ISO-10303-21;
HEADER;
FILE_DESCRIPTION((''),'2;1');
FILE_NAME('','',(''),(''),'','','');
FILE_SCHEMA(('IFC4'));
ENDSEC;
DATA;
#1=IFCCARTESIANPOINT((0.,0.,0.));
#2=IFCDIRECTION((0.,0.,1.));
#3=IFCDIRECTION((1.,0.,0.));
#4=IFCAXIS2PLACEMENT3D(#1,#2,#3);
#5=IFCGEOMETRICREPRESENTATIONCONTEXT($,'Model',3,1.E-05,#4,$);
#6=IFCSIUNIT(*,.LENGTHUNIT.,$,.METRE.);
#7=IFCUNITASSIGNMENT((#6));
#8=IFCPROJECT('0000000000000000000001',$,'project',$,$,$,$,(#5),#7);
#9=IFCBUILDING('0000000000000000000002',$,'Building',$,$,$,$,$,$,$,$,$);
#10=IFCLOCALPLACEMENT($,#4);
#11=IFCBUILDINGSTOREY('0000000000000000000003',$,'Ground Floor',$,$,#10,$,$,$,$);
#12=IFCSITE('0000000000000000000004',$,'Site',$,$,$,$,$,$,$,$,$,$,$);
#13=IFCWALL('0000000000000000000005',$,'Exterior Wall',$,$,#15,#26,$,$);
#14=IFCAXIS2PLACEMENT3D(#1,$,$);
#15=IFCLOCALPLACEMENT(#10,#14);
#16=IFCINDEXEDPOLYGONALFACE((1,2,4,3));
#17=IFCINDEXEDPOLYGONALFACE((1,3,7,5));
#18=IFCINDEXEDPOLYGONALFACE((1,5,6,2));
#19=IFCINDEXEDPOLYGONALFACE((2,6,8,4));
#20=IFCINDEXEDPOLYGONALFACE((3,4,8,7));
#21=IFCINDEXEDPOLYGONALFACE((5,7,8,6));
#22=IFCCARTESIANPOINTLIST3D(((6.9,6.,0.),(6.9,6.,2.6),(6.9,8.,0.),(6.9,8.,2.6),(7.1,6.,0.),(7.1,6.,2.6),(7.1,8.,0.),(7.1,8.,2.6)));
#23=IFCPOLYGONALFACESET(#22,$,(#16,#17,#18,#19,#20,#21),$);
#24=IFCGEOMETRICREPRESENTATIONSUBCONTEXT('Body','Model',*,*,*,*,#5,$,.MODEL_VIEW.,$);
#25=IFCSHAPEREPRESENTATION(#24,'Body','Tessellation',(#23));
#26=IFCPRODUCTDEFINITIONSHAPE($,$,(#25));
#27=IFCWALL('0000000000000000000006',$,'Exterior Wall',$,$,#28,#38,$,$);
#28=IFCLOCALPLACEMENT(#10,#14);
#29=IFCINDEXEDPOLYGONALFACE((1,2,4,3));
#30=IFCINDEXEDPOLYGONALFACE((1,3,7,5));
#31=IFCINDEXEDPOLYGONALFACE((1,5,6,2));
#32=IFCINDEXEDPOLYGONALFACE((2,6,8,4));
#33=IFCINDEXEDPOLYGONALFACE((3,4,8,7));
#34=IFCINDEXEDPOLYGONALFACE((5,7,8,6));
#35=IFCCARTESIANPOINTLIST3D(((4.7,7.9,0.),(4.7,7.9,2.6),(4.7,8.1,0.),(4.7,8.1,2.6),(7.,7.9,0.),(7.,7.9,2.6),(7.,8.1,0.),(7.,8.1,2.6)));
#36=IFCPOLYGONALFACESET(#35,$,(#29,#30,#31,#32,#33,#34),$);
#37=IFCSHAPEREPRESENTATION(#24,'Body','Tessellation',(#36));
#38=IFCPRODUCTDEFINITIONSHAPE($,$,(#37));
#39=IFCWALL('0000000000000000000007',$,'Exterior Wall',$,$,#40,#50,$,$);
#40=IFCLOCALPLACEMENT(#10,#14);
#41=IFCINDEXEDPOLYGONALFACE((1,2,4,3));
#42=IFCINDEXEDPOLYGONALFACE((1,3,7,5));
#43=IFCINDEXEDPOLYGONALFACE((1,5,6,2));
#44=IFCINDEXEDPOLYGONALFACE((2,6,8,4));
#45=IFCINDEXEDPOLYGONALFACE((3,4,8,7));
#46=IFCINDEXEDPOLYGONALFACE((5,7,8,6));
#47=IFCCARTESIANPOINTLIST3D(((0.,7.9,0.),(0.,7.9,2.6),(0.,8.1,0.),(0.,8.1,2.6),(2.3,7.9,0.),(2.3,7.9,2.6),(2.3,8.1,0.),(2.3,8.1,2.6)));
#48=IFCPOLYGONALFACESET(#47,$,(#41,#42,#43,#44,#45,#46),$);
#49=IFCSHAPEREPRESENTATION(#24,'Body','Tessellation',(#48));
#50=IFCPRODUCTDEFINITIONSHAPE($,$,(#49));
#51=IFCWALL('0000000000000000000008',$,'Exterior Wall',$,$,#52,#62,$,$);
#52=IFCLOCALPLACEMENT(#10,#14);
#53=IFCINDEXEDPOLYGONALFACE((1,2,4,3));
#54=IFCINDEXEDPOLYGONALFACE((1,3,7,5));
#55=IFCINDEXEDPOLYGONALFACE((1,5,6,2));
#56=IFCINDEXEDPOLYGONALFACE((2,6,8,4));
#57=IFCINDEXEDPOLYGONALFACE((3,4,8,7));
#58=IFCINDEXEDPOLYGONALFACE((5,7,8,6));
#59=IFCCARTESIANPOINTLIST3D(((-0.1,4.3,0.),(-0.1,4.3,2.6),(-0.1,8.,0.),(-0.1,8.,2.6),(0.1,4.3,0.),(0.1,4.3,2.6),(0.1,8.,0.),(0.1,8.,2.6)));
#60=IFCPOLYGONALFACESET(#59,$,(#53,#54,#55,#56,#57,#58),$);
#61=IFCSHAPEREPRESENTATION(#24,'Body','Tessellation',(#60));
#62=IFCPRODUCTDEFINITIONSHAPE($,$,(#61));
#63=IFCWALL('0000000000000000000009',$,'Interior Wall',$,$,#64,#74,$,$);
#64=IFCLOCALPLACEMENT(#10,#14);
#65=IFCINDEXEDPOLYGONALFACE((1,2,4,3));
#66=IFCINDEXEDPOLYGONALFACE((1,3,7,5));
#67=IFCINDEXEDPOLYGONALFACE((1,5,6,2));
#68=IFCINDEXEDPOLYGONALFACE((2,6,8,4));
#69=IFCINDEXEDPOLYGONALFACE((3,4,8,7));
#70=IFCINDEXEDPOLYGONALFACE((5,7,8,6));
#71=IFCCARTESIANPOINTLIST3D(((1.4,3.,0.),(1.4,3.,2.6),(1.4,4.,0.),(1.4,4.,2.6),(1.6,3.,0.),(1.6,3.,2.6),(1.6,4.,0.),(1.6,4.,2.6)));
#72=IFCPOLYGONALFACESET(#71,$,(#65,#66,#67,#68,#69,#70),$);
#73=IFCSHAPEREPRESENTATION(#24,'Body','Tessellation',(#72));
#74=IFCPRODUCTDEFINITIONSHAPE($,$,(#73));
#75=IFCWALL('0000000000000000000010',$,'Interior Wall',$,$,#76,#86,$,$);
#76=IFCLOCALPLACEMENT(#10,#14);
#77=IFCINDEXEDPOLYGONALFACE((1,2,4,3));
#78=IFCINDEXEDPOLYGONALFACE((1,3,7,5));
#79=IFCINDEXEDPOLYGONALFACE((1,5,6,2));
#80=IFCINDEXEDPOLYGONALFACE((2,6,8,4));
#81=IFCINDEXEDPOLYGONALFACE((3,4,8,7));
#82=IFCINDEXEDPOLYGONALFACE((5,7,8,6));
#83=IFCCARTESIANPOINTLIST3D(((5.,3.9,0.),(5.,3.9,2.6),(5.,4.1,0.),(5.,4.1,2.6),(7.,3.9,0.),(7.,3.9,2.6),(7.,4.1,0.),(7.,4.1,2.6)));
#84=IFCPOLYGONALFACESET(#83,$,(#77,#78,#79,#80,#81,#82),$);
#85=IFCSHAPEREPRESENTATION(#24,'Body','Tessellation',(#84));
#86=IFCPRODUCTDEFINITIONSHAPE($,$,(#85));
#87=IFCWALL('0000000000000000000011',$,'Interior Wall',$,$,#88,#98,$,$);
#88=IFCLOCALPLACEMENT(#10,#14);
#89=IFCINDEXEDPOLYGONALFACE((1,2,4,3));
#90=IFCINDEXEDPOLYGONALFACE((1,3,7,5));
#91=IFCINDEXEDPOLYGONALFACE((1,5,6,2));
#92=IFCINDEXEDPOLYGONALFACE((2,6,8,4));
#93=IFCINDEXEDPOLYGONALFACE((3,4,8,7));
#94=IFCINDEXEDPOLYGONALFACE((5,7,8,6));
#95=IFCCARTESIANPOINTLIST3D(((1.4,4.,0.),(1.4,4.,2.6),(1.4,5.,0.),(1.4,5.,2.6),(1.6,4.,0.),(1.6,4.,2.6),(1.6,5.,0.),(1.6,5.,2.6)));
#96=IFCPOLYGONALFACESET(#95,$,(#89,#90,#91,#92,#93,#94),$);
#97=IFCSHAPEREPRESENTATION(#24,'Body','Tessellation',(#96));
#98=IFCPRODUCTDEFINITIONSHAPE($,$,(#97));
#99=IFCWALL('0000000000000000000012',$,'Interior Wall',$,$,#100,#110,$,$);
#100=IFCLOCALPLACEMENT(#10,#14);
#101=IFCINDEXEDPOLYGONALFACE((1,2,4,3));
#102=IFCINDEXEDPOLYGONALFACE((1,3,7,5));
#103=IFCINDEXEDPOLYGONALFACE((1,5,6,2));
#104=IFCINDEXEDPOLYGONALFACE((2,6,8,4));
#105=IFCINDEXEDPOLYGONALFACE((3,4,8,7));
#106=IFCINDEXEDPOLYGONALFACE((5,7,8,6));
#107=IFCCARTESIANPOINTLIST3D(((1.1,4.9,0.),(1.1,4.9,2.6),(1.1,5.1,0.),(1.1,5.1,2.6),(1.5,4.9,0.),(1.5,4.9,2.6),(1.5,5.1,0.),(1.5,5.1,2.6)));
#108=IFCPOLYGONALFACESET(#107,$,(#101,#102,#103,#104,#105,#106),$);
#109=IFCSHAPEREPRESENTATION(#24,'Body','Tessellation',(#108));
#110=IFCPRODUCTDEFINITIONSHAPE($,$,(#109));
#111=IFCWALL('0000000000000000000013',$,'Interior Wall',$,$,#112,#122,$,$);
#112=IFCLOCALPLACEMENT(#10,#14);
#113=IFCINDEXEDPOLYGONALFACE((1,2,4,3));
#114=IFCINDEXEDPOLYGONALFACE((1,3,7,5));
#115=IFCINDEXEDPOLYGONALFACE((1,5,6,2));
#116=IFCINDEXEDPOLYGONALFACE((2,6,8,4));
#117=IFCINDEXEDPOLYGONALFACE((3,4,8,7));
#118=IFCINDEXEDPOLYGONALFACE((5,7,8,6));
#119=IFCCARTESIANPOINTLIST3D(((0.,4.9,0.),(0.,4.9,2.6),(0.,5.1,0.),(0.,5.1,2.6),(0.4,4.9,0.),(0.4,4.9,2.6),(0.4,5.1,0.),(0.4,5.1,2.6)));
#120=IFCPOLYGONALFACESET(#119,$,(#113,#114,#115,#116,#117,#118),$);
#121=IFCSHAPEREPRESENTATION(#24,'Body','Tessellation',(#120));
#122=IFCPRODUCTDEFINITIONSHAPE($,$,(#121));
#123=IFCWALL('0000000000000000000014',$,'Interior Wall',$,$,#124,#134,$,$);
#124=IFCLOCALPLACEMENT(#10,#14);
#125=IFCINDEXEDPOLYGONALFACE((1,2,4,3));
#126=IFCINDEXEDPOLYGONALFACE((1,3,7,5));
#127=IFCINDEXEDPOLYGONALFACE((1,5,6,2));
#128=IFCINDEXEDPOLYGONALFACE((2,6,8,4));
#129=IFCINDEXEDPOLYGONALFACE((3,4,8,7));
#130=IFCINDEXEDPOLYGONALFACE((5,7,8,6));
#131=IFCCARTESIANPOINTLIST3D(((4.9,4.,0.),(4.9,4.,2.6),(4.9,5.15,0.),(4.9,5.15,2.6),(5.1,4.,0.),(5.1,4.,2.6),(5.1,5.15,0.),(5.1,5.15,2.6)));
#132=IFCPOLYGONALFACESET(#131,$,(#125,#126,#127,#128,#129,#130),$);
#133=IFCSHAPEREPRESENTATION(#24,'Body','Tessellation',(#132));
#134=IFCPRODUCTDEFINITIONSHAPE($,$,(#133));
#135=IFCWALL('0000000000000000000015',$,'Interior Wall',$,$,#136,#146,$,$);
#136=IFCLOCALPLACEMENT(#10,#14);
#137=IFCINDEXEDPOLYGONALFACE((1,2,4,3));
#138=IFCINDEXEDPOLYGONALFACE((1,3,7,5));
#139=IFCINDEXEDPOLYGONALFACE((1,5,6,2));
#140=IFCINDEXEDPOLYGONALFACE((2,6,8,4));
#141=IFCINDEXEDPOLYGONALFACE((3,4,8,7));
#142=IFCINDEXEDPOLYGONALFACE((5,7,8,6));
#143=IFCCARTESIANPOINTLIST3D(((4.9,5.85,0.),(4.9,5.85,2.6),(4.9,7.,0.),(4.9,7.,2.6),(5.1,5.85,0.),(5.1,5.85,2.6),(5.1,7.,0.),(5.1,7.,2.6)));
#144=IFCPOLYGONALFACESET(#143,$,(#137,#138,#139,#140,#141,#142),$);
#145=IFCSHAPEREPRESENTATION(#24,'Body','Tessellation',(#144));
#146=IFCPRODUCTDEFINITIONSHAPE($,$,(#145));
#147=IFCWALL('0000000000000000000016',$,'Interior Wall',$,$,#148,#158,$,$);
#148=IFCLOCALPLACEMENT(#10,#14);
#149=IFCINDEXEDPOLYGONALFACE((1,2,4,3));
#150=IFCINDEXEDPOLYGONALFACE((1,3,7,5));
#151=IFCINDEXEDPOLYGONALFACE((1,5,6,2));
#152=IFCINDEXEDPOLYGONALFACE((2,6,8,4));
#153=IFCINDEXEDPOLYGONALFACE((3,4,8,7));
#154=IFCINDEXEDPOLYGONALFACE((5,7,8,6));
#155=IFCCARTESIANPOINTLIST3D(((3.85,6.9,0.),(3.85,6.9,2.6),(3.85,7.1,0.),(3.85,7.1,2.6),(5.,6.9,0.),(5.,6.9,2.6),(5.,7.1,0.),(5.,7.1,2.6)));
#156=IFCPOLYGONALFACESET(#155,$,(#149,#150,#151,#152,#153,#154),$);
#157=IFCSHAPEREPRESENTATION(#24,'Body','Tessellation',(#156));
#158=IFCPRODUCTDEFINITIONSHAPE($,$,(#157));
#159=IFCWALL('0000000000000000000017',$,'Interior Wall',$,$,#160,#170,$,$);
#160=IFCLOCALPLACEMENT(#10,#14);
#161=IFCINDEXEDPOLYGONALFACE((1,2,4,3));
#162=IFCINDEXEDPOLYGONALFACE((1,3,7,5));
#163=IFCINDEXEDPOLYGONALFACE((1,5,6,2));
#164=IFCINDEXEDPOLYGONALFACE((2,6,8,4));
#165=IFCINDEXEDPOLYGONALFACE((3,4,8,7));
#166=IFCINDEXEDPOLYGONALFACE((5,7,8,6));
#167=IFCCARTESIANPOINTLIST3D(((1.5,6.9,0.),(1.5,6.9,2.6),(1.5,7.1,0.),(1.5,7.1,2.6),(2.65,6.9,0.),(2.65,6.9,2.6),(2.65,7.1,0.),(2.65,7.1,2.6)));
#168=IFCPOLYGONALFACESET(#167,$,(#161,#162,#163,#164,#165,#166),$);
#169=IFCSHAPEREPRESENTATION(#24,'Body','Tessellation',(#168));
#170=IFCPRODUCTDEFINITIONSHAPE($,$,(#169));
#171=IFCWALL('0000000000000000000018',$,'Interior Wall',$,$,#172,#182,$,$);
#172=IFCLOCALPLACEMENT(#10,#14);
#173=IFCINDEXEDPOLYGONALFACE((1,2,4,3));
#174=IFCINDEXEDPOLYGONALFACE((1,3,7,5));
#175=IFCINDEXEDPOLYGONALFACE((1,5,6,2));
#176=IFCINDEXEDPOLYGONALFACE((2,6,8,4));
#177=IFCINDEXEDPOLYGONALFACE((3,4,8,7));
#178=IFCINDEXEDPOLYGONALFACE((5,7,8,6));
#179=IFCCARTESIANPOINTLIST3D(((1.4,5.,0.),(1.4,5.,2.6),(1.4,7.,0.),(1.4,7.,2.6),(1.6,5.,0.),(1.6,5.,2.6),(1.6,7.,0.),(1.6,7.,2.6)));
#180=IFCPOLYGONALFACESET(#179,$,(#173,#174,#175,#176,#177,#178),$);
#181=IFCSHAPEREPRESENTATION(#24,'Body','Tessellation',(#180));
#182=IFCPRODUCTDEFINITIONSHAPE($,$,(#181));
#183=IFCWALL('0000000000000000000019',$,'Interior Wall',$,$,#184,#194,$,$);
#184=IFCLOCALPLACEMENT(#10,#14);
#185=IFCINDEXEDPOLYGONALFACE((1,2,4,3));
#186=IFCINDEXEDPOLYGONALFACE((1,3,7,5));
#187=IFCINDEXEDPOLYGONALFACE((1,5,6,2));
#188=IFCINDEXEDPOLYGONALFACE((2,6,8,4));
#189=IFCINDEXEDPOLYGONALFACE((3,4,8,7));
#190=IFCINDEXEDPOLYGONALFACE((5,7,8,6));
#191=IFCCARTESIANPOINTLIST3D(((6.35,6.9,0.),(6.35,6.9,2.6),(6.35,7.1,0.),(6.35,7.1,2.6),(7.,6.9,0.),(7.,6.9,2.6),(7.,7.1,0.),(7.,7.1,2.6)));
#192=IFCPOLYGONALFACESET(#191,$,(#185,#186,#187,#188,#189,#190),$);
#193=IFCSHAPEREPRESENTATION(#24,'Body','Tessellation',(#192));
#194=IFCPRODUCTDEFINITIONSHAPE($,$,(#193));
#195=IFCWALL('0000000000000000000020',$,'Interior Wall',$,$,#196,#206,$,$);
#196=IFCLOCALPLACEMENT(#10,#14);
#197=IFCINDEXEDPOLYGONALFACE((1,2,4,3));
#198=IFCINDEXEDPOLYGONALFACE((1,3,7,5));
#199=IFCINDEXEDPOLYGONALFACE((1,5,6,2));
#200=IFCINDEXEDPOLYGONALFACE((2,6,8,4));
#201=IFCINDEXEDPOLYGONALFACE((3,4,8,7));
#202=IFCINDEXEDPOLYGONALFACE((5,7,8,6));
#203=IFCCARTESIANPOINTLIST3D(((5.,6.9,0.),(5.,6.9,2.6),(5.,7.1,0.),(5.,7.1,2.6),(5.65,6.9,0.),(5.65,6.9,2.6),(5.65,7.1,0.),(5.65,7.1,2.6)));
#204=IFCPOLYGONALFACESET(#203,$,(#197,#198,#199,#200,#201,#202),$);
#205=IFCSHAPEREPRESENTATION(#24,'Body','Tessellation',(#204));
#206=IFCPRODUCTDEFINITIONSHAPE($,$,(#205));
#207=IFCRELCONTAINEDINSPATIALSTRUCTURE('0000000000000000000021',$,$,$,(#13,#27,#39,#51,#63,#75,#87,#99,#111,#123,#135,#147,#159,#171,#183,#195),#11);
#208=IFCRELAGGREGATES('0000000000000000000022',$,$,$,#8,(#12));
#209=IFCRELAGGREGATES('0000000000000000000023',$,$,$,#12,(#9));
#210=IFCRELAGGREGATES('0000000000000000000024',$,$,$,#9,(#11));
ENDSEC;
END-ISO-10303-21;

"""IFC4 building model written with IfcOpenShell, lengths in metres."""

from ifc_helpers import new_model, si_unit, frame, origin_with_axes, place, context, subcontext, project, spatial, indexed_curve, outline, extrude, element, save


model = new_model("IFC4")

# Units and contexts
model_context = context("Model", 3, precision=1e-05, world=origin_with_axes())
body_context = subcontext(model_context, "Body", "Model", "MODEL_VIEW")
ifc_project = project(units=[si_unit("LENGTHUNIT", "METRE")], contexts=[model_context])

# Site, building, storey
site = spatial("IfcSite", under=ifc_project, Name="Site")
building = spatial("IfcBuilding", under=site, Name="Building")
storey_placement = place(None, origin_with_axes())
storey = spatial("IfcBuildingStorey", under=building, at=storey_placement, Name="Ground Floor")

# Walls
wall_1_placement = place(storey_placement, frame((7.0, 6.0, 0.0), z_axis=(0.0, 0.0, 1.0), x_axis=(0.0, 1.0, 0.0)))
element("IfcWall", 1, at=wall_1_placement, inside=storey, Name="Exterior Wall", context=body_context, shape_type="SweptSolid", body=[
    extrude(outline(indexed_curve([(0.0, 0.0), (0.0, 0.2), (2.0, 0.2), (2.0, 0.0), (0.0, 0.0)], self_intersect=False)), frame((0.0, -0.1, 0.0), z_axis=(0.0, 0.0, 1.0), x_axis=(1.0, 0.0, 0.0)), (0.0, 0.0, 1.0), 2.6),
])
for number, where, z_axis, x_axis, name in (
    (2, (7.0, 8.0, 0.0), (0.0, 0.0, 1.0), (-1.0, 0.0, 0.0), "Exterior Wall"),
    (3, (2.3, 8.0, 0.0), (0.0, 0.0, 1.0), (-1.0, 0.0, 0.0), "Exterior Wall"),
):
    element("IfcWall", number, at=place(storey_placement, frame(where, z_axis=z_axis, x_axis=x_axis)), inside=storey, Name=name, context=body_context, shape_type="SweptSolid", body=[
        extrude(outline(indexed_curve([(0.0, 0.0), (0.0, 0.2), (2.3, 0.2), (2.3, 0.0), (0.0, 0.0)], self_intersect=False)), frame((0.0, -0.1, 0.0), z_axis=(0.0, 0.0, 1.0), x_axis=(1.0, 0.0, 0.0)), (0.0, 0.0, 1.0), 2.6),
    ])
wall_2_placement = place(storey_placement, frame((0.0, 8.0, 0.0), z_axis=(0.0, 0.0, 1.0), x_axis=(0.0, -1.0, 0.0)))
element("IfcWall", 4, at=wall_2_placement, inside=storey, Name="Exterior Wall", context=body_context, shape_type="SweptSolid", body=[
    extrude(outline(indexed_curve([(0.0, 0.0), (0.0, 0.2), (3.7, 0.2), (3.7, 0.0), (0.0, 0.0)], self_intersect=False)), frame((0.0, -0.1, 0.0), z_axis=(0.0, 0.0, 1.0), x_axis=(1.0, 0.0, 0.0)), (0.0, 0.0, 1.0), 2.6),
])
wall_3_placement = place(storey_placement, frame((1.5, 4.0, 0.0), z_axis=(0.0, 0.0, 1.0), x_axis=(0.0, -1.0, 0.0)))
element("IfcWall", 5, at=wall_3_placement, inside=storey, Name="Interior Wall", context=body_context, shape_type="SweptSolid", body=[
    extrude(outline(indexed_curve([(0.0, 0.0), (0.0, 0.2), (1.0, 0.2), (1.0, 0.0), (0.0, 0.0)], self_intersect=False)), frame((0.0, -0.1, 0.0), z_axis=(0.0, 0.0, 1.0), x_axis=(1.0, 0.0, 0.0)), (0.0, 0.0, 1.0), 2.6),
])
wall_4_placement = place(storey_placement, frame((7.0, 4.0, 0.0), z_axis=(0.0, 0.0, 1.0), x_axis=(-1.0, 0.0, 0.0)))
element("IfcWall", 6, at=wall_4_placement, inside=storey, Name="Interior Wall", context=body_context, shape_type="SweptSolid", body=[
    extrude(outline(indexed_curve([(0.0, 0.0), (0.0, 0.2), (2.0, 0.2), (2.0, 0.0), (0.0, 0.0)], self_intersect=False)), frame((0.0, -0.1, 0.0), z_axis=(0.0, 0.0, 1.0), x_axis=(1.0, 0.0, 0.0)), (0.0, 0.0, 1.0), 2.6),
])
wall_5_placement = place(storey_placement, frame((1.5, 4.0, 0.0), z_axis=(0.0, 0.0, 1.0), x_axis=(0.0, 1.0, 0.0)))
element("IfcWall", 7, at=wall_5_placement, inside=storey, Name="Interior Wall", context=body_context, shape_type="SweptSolid", body=[
    extrude(outline(indexed_curve([(0.0, 0.0), (0.0, 0.2), (1.0, 0.2), (1.0, 0.0), (0.0, 0.0)], self_intersect=False)), frame((0.0, -0.1, 0.0), z_axis=(0.0, 0.0, 1.0), x_axis=(1.0, 0.0, 0.0)), (0.0, 0.0, 1.0), 2.6),
])
for number, where, z_axis, x_axis, name in (
    (8, (1.5, 5.0, 0.0), (0.0, 0.0, 1.0), (-1.0, 0.0, 0.0), "Interior Wall"),
    (9, (0.4, 5.0, 0.0), (0.0, 0.0, 1.0), (-1.0, 0.0, 0.0), "Interior Wall"),
):
    element("IfcWall", number, at=place(storey_placement, frame(where, z_axis=z_axis, x_axis=x_axis)), inside=storey, Name=name, context=body_context, shape_type="SweptSolid", body=[
        extrude(outline(indexed_curve([(0.0, 0.0), (0.0, 0.2), (0.4, 0.2), (0.4, 0.0), (0.0, 0.0)], self_intersect=False)), frame((0.0, -0.1, 0.0), z_axis=(0.0, 0.0, 1.0), x_axis=(1.0, 0.0, 0.0)), (0.0, 0.0, 1.0), 2.6),
    ])
for number, where, z_axis, x_axis, name in (
    (10, (5.0, 4.0, 0.0), (0.0, 0.0, 1.0), (0.0, 1.0, 0.0), "Interior Wall"),
    (11, (5.0, 5.85, 0.0), (0.0, 0.0, 1.0), (0.0, 1.0, 0.0), "Interior Wall"),
):
    element("IfcWall", number, at=place(storey_placement, frame(where, z_axis=z_axis, x_axis=x_axis)), inside=storey, Name=name, context=body_context, shape_type="SweptSolid", body=[
        extrude(outline(indexed_curve([(0.0, 0.0), (0.0, 0.2), (1.15, 0.2), (1.15, 0.0), (0.0, 0.0)], self_intersect=False)), frame((0.0, -0.1, 0.0), z_axis=(0.0, 0.0, 1.0), x_axis=(1.0, 0.0, 0.0)), (0.0, 0.0, 1.0), 2.6),
    ])
for number, where, z_axis, x_axis, name in (
    (12, (5.0, 7.0, 0.0), (0.0, 0.0, 1.0), (-1.0, 0.0, 0.0), "Interior Wall"),
    (13, (2.65, 7.0, 0.0), (0.0, 0.0, 1.0), (-1.0, 0.0, 0.0), "Interior Wall"),
):
    element("IfcWall", number, at=place(storey_placement, frame(where, z_axis=z_axis, x_axis=x_axis)), inside=storey, Name=name, context=body_context, shape_type="SweptSolid", body=[
        extrude(outline(indexed_curve([(0.0, 0.0), (0.0, 0.2), (1.15, 0.2), (1.15, 0.0), (0.0, 0.0)], self_intersect=False)), frame((0.0, -0.1, 0.0), z_axis=(0.0, 0.0, 1.0), x_axis=(1.0, 0.0, 0.0)), (0.0, 0.0, 1.0), 2.6),
    ])
wall_6_placement = place(storey_placement, frame((1.5, 7.0, 0.0), z_axis=(0.0, 0.0, 1.0), x_axis=(0.0, -1.0, 0.0)))
element("IfcWall", 14, at=wall_6_placement, inside=storey, Name="Interior Wall", context=body_context, shape_type="SweptSolid", body=[
    extrude(outline(indexed_curve([(0.0, 0.0), (0.0, 0.2), (2.0, 0.2), (2.0, 0.0), (0.0, 0.0)], self_intersect=False)), frame((0.0, -0.1, 0.0), z_axis=(0.0, 0.0, 1.0), x_axis=(1.0, 0.0, 0.0)), (0.0, 0.0, 1.0), 2.6),
])
for number, where, z_axis, x_axis, name in (
    (15, (7.0, 7.0, 0.0), (0.0, 0.0, 1.0), (-1.0, 0.0, 0.0), "Interior Wall"),
    (16, (5.65, 7.0, 0.0), (0.0, 0.0, 1.0), (-1.0, 0.0, 0.0), "Interior Wall"),
):
    element("IfcWall", number, at=place(storey_placement, frame(where, z_axis=z_axis, x_axis=x_axis)), inside=storey, Name=name, context=body_context, shape_type="SweptSolid", body=[
        extrude(outline(indexed_curve([(0.0, 0.0), (0.0, 0.2), (0.65, 0.2), (0.65, 0.0), (0.0, 0.0)], self_intersect=False)), frame((0.0, -0.1, 0.0), z_axis=(0.0, 0.0, 1.0), x_axis=(1.0, 0.0, 0.0)), (0.0, 0.0, 1.0), 2.6),
    ])

save(model, "model.ifc")
